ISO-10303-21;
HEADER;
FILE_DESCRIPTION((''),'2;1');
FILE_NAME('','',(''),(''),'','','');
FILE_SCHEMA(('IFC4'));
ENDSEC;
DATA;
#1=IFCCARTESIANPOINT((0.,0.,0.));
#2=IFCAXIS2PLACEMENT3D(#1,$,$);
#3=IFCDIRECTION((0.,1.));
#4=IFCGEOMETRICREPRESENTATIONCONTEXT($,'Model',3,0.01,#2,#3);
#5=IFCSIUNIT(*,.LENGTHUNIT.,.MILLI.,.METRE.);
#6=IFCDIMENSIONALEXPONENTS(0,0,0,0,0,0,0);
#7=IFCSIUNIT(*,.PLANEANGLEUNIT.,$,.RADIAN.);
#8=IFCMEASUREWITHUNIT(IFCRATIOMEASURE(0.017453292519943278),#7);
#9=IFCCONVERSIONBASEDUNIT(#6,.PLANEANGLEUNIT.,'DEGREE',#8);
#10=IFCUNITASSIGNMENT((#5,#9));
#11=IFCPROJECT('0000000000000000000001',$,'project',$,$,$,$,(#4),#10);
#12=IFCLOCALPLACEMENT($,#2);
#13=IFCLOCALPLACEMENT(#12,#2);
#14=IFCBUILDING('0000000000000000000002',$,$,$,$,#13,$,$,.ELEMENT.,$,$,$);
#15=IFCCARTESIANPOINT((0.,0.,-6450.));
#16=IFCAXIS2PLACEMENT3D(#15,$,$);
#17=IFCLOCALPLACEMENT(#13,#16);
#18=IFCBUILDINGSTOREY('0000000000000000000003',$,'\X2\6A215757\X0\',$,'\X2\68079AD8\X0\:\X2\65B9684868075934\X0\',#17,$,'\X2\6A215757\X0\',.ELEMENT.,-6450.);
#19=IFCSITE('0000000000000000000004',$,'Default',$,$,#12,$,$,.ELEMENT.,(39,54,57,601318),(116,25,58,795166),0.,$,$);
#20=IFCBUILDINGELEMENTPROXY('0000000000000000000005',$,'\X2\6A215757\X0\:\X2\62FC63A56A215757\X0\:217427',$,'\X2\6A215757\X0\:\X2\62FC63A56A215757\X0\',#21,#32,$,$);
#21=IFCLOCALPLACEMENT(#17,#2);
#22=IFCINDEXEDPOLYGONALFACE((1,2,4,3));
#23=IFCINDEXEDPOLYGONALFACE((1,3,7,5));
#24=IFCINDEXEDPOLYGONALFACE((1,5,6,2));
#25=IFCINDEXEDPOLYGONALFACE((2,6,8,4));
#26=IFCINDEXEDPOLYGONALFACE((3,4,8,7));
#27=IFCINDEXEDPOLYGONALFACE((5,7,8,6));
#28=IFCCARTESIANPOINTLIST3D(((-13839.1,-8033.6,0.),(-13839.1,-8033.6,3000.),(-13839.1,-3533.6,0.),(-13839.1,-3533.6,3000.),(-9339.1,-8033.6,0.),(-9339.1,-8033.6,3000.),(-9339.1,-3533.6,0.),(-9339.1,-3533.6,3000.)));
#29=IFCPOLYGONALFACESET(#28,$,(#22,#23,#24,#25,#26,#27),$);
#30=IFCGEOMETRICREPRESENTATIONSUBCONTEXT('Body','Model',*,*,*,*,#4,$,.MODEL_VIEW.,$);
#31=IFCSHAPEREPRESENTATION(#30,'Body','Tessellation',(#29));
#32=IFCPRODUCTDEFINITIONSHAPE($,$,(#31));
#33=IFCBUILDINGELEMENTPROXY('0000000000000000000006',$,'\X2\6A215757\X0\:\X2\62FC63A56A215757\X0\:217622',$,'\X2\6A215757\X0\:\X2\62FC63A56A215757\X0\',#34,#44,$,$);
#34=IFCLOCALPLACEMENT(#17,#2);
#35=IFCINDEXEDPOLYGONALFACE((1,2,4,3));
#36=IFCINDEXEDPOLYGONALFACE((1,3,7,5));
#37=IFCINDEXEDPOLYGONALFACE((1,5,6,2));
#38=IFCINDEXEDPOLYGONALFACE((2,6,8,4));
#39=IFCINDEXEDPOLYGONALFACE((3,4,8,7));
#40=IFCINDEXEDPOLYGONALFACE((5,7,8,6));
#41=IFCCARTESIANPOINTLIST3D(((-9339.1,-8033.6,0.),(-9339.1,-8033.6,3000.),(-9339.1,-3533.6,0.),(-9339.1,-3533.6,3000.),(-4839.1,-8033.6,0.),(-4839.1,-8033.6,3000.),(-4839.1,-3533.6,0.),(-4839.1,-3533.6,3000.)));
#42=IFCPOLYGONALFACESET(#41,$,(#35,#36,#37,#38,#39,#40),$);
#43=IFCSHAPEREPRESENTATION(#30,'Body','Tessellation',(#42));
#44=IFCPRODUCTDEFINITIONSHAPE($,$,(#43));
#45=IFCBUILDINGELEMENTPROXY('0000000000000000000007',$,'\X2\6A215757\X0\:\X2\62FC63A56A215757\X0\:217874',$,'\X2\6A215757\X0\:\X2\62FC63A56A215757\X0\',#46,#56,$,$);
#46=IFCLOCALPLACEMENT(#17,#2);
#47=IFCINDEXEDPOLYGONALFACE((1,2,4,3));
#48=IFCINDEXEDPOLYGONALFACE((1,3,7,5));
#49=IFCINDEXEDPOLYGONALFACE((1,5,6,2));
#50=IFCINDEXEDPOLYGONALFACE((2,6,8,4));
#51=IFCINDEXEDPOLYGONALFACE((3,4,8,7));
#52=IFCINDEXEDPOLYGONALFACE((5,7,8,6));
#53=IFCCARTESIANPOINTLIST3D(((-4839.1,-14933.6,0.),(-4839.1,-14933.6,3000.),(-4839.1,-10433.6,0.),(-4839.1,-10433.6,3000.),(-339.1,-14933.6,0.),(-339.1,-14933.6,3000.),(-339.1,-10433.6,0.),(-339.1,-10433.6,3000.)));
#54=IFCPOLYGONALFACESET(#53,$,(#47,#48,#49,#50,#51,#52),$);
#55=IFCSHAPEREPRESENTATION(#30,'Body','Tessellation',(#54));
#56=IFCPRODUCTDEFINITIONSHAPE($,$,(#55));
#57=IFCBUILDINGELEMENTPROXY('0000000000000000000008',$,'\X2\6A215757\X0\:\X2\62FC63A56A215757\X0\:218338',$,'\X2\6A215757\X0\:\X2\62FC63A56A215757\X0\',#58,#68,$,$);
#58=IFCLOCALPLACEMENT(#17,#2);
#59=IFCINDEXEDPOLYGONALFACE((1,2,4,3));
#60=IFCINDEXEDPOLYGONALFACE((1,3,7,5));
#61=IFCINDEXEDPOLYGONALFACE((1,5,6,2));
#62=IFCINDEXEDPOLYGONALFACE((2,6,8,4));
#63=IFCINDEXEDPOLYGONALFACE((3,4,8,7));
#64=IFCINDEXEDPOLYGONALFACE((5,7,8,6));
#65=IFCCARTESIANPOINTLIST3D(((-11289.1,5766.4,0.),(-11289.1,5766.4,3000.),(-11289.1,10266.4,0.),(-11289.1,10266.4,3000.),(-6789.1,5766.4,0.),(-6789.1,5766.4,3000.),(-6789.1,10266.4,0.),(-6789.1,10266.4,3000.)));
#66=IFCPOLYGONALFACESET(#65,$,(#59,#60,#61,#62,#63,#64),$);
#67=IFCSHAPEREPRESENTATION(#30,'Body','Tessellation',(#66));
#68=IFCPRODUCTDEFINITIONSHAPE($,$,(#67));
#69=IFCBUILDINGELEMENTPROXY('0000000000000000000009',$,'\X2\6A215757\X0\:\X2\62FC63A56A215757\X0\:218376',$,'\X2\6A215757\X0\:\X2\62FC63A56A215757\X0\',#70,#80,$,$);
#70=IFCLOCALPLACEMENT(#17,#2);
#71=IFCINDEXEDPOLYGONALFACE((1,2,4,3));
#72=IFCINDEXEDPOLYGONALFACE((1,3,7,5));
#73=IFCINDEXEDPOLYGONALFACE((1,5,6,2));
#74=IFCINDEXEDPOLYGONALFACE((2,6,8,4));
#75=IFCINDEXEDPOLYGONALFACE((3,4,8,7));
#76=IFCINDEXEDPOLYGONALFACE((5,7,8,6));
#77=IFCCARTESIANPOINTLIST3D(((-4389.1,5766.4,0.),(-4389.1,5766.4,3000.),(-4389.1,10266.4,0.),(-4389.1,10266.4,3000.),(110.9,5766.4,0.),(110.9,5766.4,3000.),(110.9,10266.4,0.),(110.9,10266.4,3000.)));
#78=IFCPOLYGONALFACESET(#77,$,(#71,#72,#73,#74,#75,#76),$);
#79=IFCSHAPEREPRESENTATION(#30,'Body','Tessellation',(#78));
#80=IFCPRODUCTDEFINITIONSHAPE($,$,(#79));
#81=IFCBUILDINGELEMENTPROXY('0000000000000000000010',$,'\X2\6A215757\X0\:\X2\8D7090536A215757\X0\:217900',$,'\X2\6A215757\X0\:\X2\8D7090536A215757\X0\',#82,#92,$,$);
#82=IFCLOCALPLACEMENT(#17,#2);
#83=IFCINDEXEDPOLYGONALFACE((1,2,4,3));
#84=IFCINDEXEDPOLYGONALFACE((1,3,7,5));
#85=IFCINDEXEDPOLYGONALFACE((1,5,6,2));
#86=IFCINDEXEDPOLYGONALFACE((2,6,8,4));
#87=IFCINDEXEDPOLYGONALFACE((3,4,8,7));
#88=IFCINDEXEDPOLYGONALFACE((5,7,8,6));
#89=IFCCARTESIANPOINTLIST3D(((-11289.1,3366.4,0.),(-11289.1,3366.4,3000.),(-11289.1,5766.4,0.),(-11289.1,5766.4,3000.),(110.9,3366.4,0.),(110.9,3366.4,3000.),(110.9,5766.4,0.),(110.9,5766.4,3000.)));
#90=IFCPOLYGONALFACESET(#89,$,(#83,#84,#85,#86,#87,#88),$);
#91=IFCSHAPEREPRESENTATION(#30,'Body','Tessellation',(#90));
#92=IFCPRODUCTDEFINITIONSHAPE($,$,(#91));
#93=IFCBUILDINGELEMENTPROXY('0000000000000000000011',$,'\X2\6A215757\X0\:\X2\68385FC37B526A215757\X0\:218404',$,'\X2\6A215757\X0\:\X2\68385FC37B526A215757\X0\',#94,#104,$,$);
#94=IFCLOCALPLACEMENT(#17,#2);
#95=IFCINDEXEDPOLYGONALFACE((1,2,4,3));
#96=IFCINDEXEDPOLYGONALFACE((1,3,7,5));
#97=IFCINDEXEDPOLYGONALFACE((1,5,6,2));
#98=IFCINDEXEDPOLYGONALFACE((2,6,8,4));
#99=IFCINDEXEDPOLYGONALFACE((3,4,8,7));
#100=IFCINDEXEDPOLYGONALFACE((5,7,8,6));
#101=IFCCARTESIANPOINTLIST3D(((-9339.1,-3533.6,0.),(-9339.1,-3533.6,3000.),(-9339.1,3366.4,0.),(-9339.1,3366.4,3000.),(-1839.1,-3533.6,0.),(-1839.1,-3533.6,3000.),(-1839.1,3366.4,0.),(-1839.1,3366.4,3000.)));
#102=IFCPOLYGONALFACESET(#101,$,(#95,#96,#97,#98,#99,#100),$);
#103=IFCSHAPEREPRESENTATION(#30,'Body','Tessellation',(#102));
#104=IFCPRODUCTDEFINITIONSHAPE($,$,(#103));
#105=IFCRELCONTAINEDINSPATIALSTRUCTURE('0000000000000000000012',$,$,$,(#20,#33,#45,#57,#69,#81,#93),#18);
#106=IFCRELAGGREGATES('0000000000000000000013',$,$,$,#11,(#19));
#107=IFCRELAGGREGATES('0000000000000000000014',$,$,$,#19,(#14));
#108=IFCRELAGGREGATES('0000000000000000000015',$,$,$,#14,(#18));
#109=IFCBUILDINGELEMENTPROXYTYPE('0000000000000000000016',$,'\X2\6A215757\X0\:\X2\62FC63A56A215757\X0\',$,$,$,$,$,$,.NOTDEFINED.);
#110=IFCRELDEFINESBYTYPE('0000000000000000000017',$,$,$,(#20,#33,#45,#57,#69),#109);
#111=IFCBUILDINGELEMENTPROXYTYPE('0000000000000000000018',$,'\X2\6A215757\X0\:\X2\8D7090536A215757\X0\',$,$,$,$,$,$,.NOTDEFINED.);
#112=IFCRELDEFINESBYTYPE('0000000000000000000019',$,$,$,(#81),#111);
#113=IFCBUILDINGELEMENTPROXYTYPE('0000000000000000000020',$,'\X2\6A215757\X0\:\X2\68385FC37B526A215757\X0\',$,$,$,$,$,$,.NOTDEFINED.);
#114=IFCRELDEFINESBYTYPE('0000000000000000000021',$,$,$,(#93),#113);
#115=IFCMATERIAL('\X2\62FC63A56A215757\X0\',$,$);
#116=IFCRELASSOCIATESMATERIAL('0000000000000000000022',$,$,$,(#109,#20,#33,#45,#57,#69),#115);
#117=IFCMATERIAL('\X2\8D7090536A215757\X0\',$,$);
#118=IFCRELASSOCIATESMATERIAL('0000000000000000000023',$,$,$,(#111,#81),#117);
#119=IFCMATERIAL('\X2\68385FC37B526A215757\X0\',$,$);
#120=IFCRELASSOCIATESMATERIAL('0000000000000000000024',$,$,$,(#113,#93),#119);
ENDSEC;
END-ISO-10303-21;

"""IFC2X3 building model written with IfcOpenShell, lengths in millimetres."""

from ifc_helpers import new_model, entity, si_unit, converted_unit, direction, frame, frame_2d, origin, place, context, subcontext, project, spatial, rectangle, extrude, source, transform, mapped, material, type_object, type_shapes, element, save


model = new_model("IFC2X3")

# Units and contexts
model_context = context("Model", 3, precision=0.01, world=origin(), true_north=direction((0.0, 1.0)))
body_context = subcontext(model_context, "Body", "Model", "MODEL_VIEW")
ifc_project = project(units=[si_unit("LENGTHUNIT", "METRE", prefix="MILLI"), converted_unit("PLANEANGLEUNIT", "DEGREE", entity("IfcRatioMeasure", 0.017453292519943278), si_unit("PLANEANGLEUNIT", "RADIAN"), dimensions=[0, 0, 0, 0, 0, 0, 0])], contexts=[model_context])

# Site, building, storey
site_placement = place(None, origin())
site = spatial("IfcSite", under=ifc_project, at=site_placement, Name="Default", CompositionType="ELEMENT", RefLatitude=(39, 54, 57, 601318), RefLongitude=(116, 25, 58, 795166), RefElevation=0.0)
building_placement = place(site_placement, origin())
building = spatial("IfcBuilding", under=site, at=building_placement, CompositionType="ELEMENT")
storey_placement = place(building_placement, frame((0.0, 0.0, -6450.0)))
storey = spatial("IfcBuildingStorey", under=building, at=storey_placement, Name="模块", ObjectType="标高:方案标头", LongName="模块", CompositionType="ELEMENT", Elevation=-6450.0)

# Building element proxies
ifc_material_1 = material(Name="拼接模块")
building_element_proxy_type_1 = type_object("IfcBuildingElementProxyType", Name="模块:拼接模块", PredefinedType="NOTDEFINED", material=ifc_material_1)
shared_shape_1 = source(origin(), body_context, "Body", "SweptSolid", [
    extrude(rectangle(XDim=4500.0, YDim=4500.0, at=frame_2d((0.0, 0.0), x_axis=(1.0, 0.0))), frame((0.0, 0.0, 0.0), z_axis=(0.0, 0.0, 1.0), x_axis=(-1.0, 0.0, 0.0)), (0.0, 0.0, 1.0), 3000.0),
])
type_shapes(building_element_proxy_type_1, [shared_shape_1])
for number, where, name in (
    (1, (-11589.1, -5783.6, 0.0), "模块:拼接模块:217427"),
    (2, (-7089.1, -5783.6, 0.0), "模块:拼接模块:217622"),
    (3, (-2589.1, -12683.6, 0.0), "模块:拼接模块:217874"),
    (4, (-9039.1, 8016.4, 0.0), "模块:拼接模块:218338"),
    (5, (-2139.1, 8016.4, 0.0), "模块:拼接模块:218376"),
):
    element("IfcBuildingElementProxy", number, at=place(storey_placement, frame(where)), inside=storey, type_object=building_element_proxy_type_1, material=ifc_material_1, Name=name, ObjectType="模块:拼接模块", context=body_context, shape_type="MappedRepresentation", body=[
        mapped(shared_shape_1, transform((0.0, 0.0, 0.0), scale=1.0)),
    ])
ifc_material_2 = material(Name="走道模块")
building_element_proxy_type_2 = type_object("IfcBuildingElementProxyType", Name="模块:走道模块", PredefinedType="NOTDEFINED", material=ifc_material_2)
shared_shape_2 = source(origin(), body_context, "Body", "SweptSolid", [
    extrude(rectangle(XDim=11400.0, YDim=2400.0, at=frame_2d((0.0, 0.0), x_axis=(1.0, 0.0))), frame((0.0, 0.0, 0.0), z_axis=(0.0, 0.0, 1.0), x_axis=(-1.0, 0.0, 0.0)), (0.0, 0.0, 1.0), 3000.0),
])
type_shapes(building_element_proxy_type_2, [shared_shape_2])
proxy_1_placement = place(storey_placement, frame((-5589.1, 4566.4, 0.0)))
element("IfcBuildingElementProxy", 6, at=proxy_1_placement, inside=storey, type_object=building_element_proxy_type_2, material=ifc_material_2, Name="模块:走道模块:217900", ObjectType="模块:走道模块", context=body_context, shape_type="MappedRepresentation", body=[
    mapped(shared_shape_2, transform((0.0, 0.0, 0.0), scale=1.0)),
])
ifc_material_3 = material(Name="核心筒模块")
building_element_proxy_type_3 = type_object("IfcBuildingElementProxyType", Name="模块:核心筒模块", PredefinedType="NOTDEFINED", material=ifc_material_3)
shared_shape_3 = source(origin(), body_context, "Body", "SweptSolid", [
    extrude(rectangle(XDim=7500.0, YDim=6900.0, at=frame_2d((0.0, 0.0), x_axis=(1.0, 0.0))), frame((0.0, 0.0, 0.0), z_axis=(0.0, 0.0, 1.0), x_axis=(-1.0, 0.0, 0.0)), (0.0, 0.0, 1.0), 3000.0),
])
type_shapes(building_element_proxy_type_3, [shared_shape_3])
proxy_2_placement = place(storey_placement, frame((-5589.1, -83.6, 0.0)))
element("IfcBuildingElementProxy", 7, at=proxy_2_placement, inside=storey, type_object=building_element_proxy_type_3, material=ifc_material_3, Name="模块:核心筒模块:218404", ObjectType="模块:核心筒模块", context=body_context, shape_type="MappedRepresentation", body=[
    mapped(shared_shape_3, transform((0.0, 0.0, 0.0), scale=1.0)),
])

save(model, "model.ifc")
